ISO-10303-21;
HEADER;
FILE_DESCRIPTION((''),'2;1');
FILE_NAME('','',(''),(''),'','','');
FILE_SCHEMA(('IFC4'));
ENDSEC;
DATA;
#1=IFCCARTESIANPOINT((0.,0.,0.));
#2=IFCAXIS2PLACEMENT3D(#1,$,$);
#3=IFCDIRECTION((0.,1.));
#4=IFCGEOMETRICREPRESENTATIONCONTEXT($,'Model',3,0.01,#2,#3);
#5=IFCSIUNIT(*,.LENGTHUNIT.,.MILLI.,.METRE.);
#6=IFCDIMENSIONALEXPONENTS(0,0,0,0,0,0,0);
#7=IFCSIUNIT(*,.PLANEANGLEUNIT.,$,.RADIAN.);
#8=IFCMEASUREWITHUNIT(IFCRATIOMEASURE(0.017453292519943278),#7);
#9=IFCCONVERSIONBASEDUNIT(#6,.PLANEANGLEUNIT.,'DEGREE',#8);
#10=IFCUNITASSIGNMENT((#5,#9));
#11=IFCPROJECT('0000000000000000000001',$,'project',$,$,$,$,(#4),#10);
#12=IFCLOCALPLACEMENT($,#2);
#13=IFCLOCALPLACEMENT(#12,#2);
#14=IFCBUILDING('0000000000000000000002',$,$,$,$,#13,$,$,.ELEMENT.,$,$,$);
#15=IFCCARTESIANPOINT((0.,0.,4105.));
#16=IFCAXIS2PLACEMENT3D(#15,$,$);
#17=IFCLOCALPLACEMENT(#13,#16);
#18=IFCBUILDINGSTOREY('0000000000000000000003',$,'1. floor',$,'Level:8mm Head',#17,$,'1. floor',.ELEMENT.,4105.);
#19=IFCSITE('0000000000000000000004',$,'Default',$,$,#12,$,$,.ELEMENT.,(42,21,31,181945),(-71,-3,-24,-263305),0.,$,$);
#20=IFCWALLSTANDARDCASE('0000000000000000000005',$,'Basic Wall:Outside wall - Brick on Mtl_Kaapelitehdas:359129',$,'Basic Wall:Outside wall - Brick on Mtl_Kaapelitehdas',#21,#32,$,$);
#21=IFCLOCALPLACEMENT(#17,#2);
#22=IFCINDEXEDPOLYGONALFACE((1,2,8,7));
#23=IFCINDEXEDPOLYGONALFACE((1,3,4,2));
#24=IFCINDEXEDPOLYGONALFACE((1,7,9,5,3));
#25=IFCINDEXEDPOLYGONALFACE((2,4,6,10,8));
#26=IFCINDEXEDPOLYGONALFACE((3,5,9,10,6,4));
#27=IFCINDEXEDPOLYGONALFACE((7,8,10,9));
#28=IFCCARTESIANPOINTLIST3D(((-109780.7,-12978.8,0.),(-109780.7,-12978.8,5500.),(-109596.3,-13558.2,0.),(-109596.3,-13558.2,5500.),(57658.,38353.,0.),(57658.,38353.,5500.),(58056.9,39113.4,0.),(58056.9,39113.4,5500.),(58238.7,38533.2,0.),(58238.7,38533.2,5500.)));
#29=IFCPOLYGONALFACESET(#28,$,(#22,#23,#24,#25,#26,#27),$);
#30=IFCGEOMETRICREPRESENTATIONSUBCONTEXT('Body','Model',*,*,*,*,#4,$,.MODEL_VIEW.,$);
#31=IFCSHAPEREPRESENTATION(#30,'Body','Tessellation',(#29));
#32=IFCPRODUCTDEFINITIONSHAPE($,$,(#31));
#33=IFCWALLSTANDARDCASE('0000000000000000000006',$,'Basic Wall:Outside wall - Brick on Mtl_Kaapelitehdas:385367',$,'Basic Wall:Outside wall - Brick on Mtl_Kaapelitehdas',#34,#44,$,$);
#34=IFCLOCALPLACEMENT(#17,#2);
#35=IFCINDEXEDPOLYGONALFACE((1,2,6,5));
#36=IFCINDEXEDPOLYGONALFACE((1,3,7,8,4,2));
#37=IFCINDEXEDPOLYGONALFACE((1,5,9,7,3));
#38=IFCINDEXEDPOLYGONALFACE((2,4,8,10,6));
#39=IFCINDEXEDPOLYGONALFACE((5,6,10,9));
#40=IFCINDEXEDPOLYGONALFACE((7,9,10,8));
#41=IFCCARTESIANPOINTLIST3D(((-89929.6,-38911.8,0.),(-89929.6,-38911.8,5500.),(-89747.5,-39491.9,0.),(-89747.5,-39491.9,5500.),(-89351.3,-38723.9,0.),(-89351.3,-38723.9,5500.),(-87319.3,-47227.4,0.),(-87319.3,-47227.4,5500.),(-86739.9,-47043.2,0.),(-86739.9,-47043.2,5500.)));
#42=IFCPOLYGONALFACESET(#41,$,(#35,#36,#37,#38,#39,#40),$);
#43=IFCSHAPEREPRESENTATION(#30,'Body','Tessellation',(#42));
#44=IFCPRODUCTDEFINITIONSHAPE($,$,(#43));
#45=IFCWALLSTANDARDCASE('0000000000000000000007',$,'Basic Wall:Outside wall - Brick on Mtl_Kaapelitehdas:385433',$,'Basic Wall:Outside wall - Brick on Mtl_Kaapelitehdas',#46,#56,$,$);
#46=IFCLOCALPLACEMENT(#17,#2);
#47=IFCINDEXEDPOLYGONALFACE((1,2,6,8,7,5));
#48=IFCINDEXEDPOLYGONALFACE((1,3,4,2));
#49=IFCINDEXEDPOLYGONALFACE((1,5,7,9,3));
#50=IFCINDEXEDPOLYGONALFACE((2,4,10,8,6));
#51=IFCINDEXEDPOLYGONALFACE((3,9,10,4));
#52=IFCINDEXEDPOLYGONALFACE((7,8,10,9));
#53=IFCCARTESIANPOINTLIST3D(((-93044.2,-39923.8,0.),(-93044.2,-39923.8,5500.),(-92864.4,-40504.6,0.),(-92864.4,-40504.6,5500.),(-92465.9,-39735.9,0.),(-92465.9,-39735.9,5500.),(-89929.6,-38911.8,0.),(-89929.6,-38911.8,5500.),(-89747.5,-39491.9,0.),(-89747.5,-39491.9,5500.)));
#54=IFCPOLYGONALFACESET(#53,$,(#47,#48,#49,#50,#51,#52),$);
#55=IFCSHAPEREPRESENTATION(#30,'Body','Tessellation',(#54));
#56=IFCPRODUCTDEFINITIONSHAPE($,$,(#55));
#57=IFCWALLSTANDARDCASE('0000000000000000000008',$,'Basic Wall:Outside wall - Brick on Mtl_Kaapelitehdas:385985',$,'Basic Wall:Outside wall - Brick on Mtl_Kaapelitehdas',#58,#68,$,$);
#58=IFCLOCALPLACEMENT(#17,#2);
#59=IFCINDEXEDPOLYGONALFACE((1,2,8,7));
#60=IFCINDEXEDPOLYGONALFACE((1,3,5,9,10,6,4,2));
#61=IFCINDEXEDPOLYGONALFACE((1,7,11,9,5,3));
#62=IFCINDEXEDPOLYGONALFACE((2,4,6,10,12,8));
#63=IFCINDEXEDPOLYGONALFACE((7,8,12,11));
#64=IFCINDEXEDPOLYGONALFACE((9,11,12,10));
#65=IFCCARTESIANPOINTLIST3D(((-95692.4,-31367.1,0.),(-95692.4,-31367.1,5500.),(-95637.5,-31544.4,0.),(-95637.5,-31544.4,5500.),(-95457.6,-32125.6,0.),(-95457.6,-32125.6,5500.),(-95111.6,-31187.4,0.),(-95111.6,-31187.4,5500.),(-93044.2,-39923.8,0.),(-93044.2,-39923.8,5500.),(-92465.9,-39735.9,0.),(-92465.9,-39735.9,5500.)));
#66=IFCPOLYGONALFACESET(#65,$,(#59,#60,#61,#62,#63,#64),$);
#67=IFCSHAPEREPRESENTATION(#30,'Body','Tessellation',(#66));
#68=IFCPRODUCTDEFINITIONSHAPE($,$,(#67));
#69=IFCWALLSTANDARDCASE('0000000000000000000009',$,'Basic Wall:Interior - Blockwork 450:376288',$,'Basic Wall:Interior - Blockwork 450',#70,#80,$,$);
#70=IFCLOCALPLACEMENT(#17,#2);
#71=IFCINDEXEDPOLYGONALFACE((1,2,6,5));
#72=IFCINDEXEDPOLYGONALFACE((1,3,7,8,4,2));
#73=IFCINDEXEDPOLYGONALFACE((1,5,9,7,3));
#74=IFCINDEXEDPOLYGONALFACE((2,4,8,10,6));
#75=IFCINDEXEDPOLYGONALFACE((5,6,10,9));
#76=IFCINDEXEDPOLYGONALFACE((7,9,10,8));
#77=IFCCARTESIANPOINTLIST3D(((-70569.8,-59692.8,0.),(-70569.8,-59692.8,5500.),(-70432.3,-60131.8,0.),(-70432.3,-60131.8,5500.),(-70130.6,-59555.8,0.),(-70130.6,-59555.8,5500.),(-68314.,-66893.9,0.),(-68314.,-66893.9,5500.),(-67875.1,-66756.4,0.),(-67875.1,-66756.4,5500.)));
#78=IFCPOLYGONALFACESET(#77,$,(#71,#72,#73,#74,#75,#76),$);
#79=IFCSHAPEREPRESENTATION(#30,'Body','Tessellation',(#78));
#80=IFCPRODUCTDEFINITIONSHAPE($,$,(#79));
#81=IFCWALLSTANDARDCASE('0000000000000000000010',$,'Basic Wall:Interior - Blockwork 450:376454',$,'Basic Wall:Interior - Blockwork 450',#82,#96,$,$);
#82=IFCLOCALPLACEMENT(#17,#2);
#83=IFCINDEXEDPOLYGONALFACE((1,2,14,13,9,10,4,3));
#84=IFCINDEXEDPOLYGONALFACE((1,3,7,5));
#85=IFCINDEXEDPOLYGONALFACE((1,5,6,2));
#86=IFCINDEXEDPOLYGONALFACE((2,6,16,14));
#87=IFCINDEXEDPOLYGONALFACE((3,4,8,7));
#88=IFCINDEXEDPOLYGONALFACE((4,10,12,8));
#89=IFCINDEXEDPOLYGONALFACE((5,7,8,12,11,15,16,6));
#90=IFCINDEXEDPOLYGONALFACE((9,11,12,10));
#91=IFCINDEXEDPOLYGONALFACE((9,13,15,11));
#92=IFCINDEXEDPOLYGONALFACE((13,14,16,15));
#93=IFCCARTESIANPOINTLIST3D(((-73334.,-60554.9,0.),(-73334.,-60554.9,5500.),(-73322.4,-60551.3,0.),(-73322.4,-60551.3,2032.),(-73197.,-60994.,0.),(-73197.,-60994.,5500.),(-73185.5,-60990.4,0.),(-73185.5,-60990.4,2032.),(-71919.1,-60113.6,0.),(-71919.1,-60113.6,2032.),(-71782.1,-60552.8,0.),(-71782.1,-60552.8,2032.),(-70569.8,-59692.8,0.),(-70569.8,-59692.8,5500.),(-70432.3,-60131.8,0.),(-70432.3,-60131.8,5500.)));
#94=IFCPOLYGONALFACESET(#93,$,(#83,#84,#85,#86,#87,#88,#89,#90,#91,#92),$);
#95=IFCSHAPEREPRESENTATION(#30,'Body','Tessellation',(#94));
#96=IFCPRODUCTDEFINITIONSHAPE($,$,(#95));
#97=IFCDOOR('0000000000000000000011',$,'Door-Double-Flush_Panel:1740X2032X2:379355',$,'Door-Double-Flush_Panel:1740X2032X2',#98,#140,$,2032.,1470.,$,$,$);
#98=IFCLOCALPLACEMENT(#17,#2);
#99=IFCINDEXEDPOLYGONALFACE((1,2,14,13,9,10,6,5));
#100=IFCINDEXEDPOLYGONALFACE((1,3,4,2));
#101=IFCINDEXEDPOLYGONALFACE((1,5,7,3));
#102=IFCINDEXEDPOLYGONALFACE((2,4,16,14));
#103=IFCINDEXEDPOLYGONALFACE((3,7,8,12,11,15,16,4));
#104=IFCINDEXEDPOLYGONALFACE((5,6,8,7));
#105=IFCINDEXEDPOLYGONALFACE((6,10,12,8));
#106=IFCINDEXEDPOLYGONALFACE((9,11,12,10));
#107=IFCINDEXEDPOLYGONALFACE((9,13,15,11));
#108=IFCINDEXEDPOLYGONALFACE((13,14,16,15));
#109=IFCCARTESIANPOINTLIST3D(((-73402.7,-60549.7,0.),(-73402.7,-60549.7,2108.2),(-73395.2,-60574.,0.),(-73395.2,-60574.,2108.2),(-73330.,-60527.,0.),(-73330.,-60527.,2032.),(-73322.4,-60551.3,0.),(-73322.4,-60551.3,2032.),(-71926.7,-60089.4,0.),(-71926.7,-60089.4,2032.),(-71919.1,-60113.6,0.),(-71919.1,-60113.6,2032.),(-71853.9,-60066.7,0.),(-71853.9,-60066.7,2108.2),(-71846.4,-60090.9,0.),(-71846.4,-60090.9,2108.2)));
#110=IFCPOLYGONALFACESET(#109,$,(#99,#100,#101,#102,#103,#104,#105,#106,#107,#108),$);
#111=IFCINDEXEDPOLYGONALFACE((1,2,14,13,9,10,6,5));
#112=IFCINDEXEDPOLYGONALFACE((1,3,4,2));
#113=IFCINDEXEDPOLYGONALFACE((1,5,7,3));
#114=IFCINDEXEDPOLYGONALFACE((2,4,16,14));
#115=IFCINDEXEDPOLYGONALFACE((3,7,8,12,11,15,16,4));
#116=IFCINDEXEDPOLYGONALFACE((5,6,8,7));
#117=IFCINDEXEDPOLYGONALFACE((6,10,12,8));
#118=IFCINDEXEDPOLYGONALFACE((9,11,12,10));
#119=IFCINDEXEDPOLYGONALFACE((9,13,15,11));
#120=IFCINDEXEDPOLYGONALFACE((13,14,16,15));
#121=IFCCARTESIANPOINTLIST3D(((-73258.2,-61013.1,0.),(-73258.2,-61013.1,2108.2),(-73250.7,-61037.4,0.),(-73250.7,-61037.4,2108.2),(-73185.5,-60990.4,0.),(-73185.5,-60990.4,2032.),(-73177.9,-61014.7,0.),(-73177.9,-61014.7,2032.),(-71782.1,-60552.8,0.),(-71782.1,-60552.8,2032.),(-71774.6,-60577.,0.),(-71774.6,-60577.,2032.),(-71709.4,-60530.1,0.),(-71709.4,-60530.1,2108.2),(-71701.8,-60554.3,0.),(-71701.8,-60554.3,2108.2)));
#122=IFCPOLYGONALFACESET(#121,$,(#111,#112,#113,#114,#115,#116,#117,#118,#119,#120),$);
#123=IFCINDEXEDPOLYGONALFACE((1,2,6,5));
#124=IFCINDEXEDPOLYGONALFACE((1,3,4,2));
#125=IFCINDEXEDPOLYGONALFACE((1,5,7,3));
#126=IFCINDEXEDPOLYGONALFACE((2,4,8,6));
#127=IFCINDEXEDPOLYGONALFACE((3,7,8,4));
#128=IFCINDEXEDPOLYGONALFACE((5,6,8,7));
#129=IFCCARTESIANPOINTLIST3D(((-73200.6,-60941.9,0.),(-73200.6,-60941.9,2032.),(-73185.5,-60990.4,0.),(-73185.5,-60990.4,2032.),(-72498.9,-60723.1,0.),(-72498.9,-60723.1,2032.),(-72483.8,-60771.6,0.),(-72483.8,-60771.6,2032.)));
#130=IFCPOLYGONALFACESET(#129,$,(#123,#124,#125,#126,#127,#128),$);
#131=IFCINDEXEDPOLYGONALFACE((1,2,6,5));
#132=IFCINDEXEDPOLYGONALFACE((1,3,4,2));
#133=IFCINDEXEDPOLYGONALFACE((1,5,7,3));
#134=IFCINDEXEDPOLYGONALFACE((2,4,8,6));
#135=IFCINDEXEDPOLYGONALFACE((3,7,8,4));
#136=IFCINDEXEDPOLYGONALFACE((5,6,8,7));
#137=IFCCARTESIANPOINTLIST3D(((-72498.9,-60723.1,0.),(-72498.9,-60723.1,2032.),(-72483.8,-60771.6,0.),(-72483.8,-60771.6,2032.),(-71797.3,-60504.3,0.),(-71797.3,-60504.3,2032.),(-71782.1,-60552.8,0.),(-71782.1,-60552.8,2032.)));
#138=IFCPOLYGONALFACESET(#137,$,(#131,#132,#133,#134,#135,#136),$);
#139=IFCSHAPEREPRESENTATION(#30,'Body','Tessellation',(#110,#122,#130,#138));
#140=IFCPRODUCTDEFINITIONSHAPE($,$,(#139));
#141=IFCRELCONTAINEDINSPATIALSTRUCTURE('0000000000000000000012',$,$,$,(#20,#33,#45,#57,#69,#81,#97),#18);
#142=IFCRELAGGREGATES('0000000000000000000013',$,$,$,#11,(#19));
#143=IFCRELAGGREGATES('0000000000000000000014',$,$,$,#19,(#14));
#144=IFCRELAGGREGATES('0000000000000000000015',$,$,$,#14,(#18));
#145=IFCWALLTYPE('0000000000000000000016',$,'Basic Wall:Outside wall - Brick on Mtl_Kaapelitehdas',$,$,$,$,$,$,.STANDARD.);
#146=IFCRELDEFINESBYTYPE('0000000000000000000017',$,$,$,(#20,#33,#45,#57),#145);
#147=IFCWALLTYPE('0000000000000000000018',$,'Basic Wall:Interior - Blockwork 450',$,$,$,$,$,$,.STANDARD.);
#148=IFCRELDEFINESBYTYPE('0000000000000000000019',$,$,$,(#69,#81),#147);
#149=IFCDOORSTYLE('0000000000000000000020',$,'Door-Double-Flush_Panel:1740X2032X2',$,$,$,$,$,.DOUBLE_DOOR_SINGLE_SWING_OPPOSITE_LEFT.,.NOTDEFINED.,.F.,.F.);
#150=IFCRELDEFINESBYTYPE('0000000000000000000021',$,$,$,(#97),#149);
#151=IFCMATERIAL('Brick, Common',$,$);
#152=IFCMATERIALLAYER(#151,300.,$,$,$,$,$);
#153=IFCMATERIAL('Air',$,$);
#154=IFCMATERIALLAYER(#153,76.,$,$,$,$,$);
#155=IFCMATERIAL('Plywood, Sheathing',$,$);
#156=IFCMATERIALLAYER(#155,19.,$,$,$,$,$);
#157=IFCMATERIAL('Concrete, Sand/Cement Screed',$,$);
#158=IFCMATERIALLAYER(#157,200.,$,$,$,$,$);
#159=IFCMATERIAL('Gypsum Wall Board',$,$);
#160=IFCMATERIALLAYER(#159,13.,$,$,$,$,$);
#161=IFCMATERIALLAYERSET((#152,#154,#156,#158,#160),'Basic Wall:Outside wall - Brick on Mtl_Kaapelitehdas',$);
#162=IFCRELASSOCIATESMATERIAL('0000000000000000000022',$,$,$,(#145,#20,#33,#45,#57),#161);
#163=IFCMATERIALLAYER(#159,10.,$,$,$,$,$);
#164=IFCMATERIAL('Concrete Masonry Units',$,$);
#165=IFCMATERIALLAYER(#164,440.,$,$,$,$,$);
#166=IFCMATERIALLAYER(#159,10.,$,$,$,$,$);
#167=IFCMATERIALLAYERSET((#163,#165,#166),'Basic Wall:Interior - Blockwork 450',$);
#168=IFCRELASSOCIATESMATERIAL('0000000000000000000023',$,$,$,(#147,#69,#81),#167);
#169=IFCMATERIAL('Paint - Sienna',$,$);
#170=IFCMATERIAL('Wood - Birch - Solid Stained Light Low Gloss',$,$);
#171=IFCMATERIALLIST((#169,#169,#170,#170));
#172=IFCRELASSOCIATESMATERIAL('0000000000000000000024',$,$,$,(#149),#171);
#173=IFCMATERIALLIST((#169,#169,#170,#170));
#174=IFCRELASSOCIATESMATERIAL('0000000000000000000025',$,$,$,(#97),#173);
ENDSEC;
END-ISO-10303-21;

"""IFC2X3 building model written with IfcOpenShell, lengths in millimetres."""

from ifc_helpers import new_model, entity, si_unit, converted_unit, direction, frame, frame_2d, origin, place, context, subcontext, project, spatial, polyline, rectangle, outline, extrude, source, transform, mapped, material, material_list, layer, layer_set, layer_usage, type_object, type_shapes, element, fill, save


model = new_model("IFC2X3")

# Units and contexts
model_context = context("Model", 3, precision=0.01, world=origin(), true_north=direction((0.0, 1.0)))
body_context = subcontext(model_context, "Body", "Model", "MODEL_VIEW")
ifc_project = project(units=[si_unit("LENGTHUNIT", "METRE", prefix="MILLI"), converted_unit("PLANEANGLEUNIT", "DEGREE", entity("IfcRatioMeasure", 0.017453292519943278), si_unit("PLANEANGLEUNIT", "RADIAN"), dimensions=[0, 0, 0, 0, 0, 0, 0])], contexts=[model_context])

# Site, building, storey
site_placement = place(None, origin())
site = spatial("IfcSite", under=ifc_project, at=site_placement, Name="Default", CompositionType="ELEMENT", RefLatitude=(42, 21, 31, 181945), RefLongitude=(-71, -3, -24, -263305), RefElevation=0.0)
building_placement = place(site_placement, origin())
building = spatial("IfcBuilding", under=site, at=building_placement, CompositionType="ELEMENT")
storey_placement = place(building_placement, frame((0.0, 0.0, 4105.0)))
storey = spatial("IfcBuildingStorey", under=building, at=storey_placement, Name="1. floor", ObjectType="Level:8mm Head", LongName="1. floor", CompositionType="ELEMENT", Elevation=4105.0)

# Walls
ifc_material_1 = material(Name="Brick, Common")
ifc_layer_1 = layer(ifc_material_1, 300.0)
ifc_material_2 = material(Name="Air")
ifc_layer_2 = layer(ifc_material_2, 76.0)
ifc_material_3 = material(Name="Plywood, Sheathing")
ifc_layer_3 = layer(ifc_material_3, 19.0)
ifc_material_4 = material(Name="Concrete, Sand/Cement Screed")
ifc_layer_4 = layer(ifc_material_4, 200.0)
ifc_material_5 = material(Name="Gypsum Wall Board")
ifc_layer_5 = layer(ifc_material_5, 13.0)
ifc_layer_set_1 = layer_set([ifc_layer_1, ifc_layer_2, ifc_layer_3, ifc_layer_4, ifc_layer_5], Name="Basic Wall:Outside wall - Brick on Mtl_Kaapelitehdas")
wall_type_1 = type_object("IfcWallType", Name="Basic Wall:Outside wall - Brick on Mtl_Kaapelitehdas", PredefinedType="STANDARD", material=ifc_layer_set_1)
ifc_layer_usage_1 = layer_usage(ifc_layer_set_1, "AXIS2", "NEGATIVE", 304.0)
wall_1_placement = place(storey_placement, frame((-109690.6, -13269.2, 0.0), z_axis=(0.0, 0.0, 1.0), x_axis=(0.955057, 0.296424, 0.0)))
element("IfcWallStandardCase", 1, at=wall_1_placement, inside=storey, type_object=wall_type_1, material=ifc_layer_usage_1, Name="Basic Wall:Outside wall - Brick on Mtl_Kaapelitehdas:359129", ObjectType="Basic Wall:Outside wall - Brick on Mtl_Kaapelitehdas", context=body_context, shape_type="SweptSolid", body=[
    extrude(outline(polyline([(175737.4, -304.0), (175735.8, 304.0), (0.0, 304.0), (4.3, -304.0), (175129.4, -304.0), (175737.4, -304.0)])), origin(), (0.0, 0.0, 1.0), 5500.0),
])
ifc_layer_usage_2 = layer_usage(ifc_layer_set_1, "AXIS2", "NEGATIVE", 304.0)
wall_2_placement = place(storey_placement, frame((-87029.3, -47136.3, 0.0), z_axis=(0.0, 0.0, 1.0), x_axis=(-0.299495, 0.954098, 0.0)))
element("IfcWallStandardCase", 2, at=wall_2_placement, inside=storey, type_object=wall_type_1, material=ifc_layer_usage_2, Name="Basic Wall:Outside wall - Brick on Mtl_Kaapelitehdas:385367", ObjectType="Basic Wall:Outside wall - Brick on Mtl_Kaapelitehdas", context=body_context, shape_type="SweptSolid", body=[
    extrude(outline(polyline([(8721.8, -304.0), (8715.7, 304.0), (8107.6, 304.0), (0.0, 304.0), (2.2, -304.0), (8721.8, -304.0)])), origin(), (0.0, 0.0, 1.0), 5500.0),
])
ifc_layer_usage_3 = layer_usage(ifc_layer_set_1, "AXIS2", "NEGATIVE", 304.0)
wall_3_placement = place(storey_placement, frame((-89835.7, -39200.9, 0.0), z_axis=(0.0, 0.0, 1.0), x_axis=(-0.951057, -0.309017, 0.0)))
element("IfcWallStandardCase", 3, at=wall_3_placement, inside=storey, type_object=wall_type_1, material=ifc_layer_usage_3, Name="Basic Wall:Outside wall - Brick on Mtl_Kaapelitehdas:385433", ObjectType="Basic Wall:Outside wall - Brick on Mtl_Kaapelitehdas", context=body_context, shape_type="SweptSolid", body=[
    extrude(outline(polyline([(3274.9, -304.0), (3283.4, 304.0), (6.1, 304.0), (0.0, -304.0), (2666.8, -304.0), (3274.9, -304.0)])), origin(), (0.0, 0.0, 1.0), 5500.0),
])
ifc_layer_usage_4 = layer_usage(ifc_layer_set_1, "AXIS2", "NEGATIVE", 304.0)
wall_4_placement = place(storey_placement, frame((-92753.8, -39833.9, 0.0), z_axis=(0.0, 0.0, 1.0), x_axis=(-0.295652, 0.955296, 0.0)))
element("IfcWallStandardCase", 4, at=wall_4_placement, inside=storey, type_object=wall_type_1, material=ifc_layer_usage_4, Name="Basic Wall:Outside wall - Brick on Mtl_Kaapelitehdas:385985", ObjectType="Basic Wall:Outside wall - Brick on Mtl_Kaapelitehdas", context=body_context, shape_type="SweptSolid", body=[
    extrude(outline(polyline([(8957.0, -304.0), (8957.0, 304.0), (8771.5, 304.0), (8163.0, 304.0), (0.0, 304.0), (8.5, -304.0), (8957.0, -304.0)])), origin(), (0.0, 0.0, 1.0), 5500.0),
])
ifc_layer_6 = layer(ifc_material_5, 10.0)
ifc_material_6 = material(Name="Concrete Masonry Units")
ifc_layer_7 = layer(ifc_material_6, 440.0)
ifc_layer_8 = layer(ifc_material_5, 10.0)
ifc_layer_set_2 = layer_set([ifc_layer_6, ifc_layer_7, ifc_layer_8], Name="Basic Wall:Interior - Blockwork 450")
ifc_layer_usage_5 = layer_usage(ifc_layer_set_2, "AXIS2", "NEGATIVE", 230.0)
wall_type_2 = type_object("IfcWallType", Name="Basic Wall:Interior - Blockwork 450", PredefinedType="STANDARD", material=ifc_layer_set_2)
wall_5_placement = place(storey_placement, frame((-70350.3, -59624.0, 0.0), z_axis=(0.0, 0.0, 1.0), x_axis=(0.298924, -0.954277, 0.0)))
element("IfcWallStandardCase", 5, at=wall_5_placement, inside=storey, type_object=wall_type_2, material=ifc_layer_usage_5, Name="Basic Wall:Interior - Blockwork 450:376288", ObjectType="Basic Wall:Interior - Blockwork 450", context=body_context, shape_type="SweptSolid", body=[
    extrude(outline(polyline([(7546.2, -230.0), (7546.2, 230.0), (0.6, 230.0), (0.0, -230.0), (460.0, -230.0), (7546.2, -230.0)])), origin(), (0.0, 0.0, 1.0), 5500.0),
])

# Wall, opening, door
ifc_layer_usage_6 = layer_usage(ifc_layer_set_2, "AXIS2", "NEGATIVE", 230.0)
wall_6_placement = place(storey_placement, frame((-70500.7, -59912.2, 0.0), z_axis=(0.0, 0.0, 1.0), x_axis=(-0.954648, -0.297735, 0.0)))
wall_6 = element("IfcWallStandardCase", 6, at=wall_6_placement, inside=storey, type_object=wall_type_2, material=ifc_layer_usage_6, Name="Basic Wall:Interior - Blockwork 450:376454", ObjectType="Basic Wall:Interior - Blockwork 450", context=body_context, shape_type="SweptSolid", body=[
    extrude(outline(polyline([(0.6, -230.0), (2896.1, -230.0), (2896.1, 230.0), (0.0, 230.0), (0.6, -230.0)])), origin(), (0.0, 0.0, 1.0), 5500.0),
])
opening_placement = place(wall_6_placement, frame((1414.0, -230.0, 0.0)))
opening = element("IfcOpeningElement", 7, at=opening_placement, cuts=wall_6, ObjectType="Opening", context=body_context, shape_type="SweptSolid", body=[
    extrude(rectangle(XDim=2032.0, YDim=1470.0, at=frame_2d((1016.0, 735.0), x_axis=(1.0, 0.0))), frame((0.0, 0.0, 0.0), z_axis=(0.0, 1.0, 0.0), x_axis=(0.0, 0.0, 1.0)), (0.0, 0.0, 1.0), 460.0),
])
ifc_material_7 = material(Name="Paint - Sienna")
ifc_material_8 = material(Name="Wood - Birch - Solid Stained Light Low Gloss")
ifc_material_list_1 = material_list([ifc_material_7, ifc_material_7, ifc_material_8, ifc_material_8])
ifc_material_list_2 = material_list([ifc_material_7, ifc_material_7, ifc_material_8, ifc_material_8])
door_style = type_object("IfcDoorStyle", Name="Door-Double-Flush_Panel:1740X2032X2", ConstructionType="NOTDEFINED", OperationType="DOUBLE_DOOR_SINGLE_SWING_OPPOSITE_LEFT", ParameterTakesPrecedence=False, Sizeable=False, material=ifc_material_list_2)
shared_shape = source(origin(), body_context, "Body", "SweptSolid", [
    extrude(outline(polyline([(-996.9, 735.0), (1035.0, 735.0), (1035.0, 811.2), (-1073.1, 811.2), (-1073.1, -811.2), (1035.0, -811.2), (1035.0, -735.0), (-996.9, -735.0), (-996.9, 735.0)])), frame((735.0, -25.4, 1035.0), z_axis=(0.0, 1.0, 0.0), x_axis=(0.0, 0.0, -1.0)), (0.0, 0.0, 1.0), 25.4),
    extrude(outline(polyline([(-996.9, 735.0), (1035.0, 735.0), (1035.0, 811.2), (-1073.1, 811.2), (-1073.1, -811.2), (1035.0, -811.2), (1035.0, -735.0), (-996.9, -735.0), (-996.9, 735.0)])), frame((735.0, 460.0, 1035.0), z_axis=(0.0, 1.0, 0.0), x_axis=(0.0, 0.0, -1.0)), (0.0, 0.0, 1.0), 25.4),
    extrude(rectangle(XDim=50.8, YDim=735.0, at=frame_2d((0.0, 0.0), x_axis=(1.0, 0.0))), frame((1102.5, 434.6, 0.0), z_axis=(0.0, 0.0, 1.0), x_axis=(0.0, -1.0, 0.0)), (0.0, 0.0, 1.0), 2032.0),
    extrude(rectangle(XDim=50.8, YDim=735.0, at=frame_2d((0.0, 0.0), x_axis=(1.0, 0.0))), frame((367.5, 434.6, 0.0), z_axis=(0.0, 0.0, 1.0), x_axis=(0.0, -1.0, 0.0)), (0.0, 0.0, 1.0), 2032.0),
])
type_shapes(door_style, [shared_shape])
door_placement = place(opening_placement, origin())
door = element("IfcDoor", 8, at=door_placement, inside=storey, type_object=door_style, material=ifc_material_list_1, Name="Door-Double-Flush_Panel:1740X2032X2:379355", ObjectType="Door-Double-Flush_Panel:1740X2032X2", OverallHeight=2032.0, OverallWidth=1470.0, context=body_context, shape_type="MappedRepresentation", body=[
    mapped(shared_shape, transform((0.0, 0.0, 0.0), scale=1.0)),
])
fill(opening, door)

save(model, "model.ifc")
